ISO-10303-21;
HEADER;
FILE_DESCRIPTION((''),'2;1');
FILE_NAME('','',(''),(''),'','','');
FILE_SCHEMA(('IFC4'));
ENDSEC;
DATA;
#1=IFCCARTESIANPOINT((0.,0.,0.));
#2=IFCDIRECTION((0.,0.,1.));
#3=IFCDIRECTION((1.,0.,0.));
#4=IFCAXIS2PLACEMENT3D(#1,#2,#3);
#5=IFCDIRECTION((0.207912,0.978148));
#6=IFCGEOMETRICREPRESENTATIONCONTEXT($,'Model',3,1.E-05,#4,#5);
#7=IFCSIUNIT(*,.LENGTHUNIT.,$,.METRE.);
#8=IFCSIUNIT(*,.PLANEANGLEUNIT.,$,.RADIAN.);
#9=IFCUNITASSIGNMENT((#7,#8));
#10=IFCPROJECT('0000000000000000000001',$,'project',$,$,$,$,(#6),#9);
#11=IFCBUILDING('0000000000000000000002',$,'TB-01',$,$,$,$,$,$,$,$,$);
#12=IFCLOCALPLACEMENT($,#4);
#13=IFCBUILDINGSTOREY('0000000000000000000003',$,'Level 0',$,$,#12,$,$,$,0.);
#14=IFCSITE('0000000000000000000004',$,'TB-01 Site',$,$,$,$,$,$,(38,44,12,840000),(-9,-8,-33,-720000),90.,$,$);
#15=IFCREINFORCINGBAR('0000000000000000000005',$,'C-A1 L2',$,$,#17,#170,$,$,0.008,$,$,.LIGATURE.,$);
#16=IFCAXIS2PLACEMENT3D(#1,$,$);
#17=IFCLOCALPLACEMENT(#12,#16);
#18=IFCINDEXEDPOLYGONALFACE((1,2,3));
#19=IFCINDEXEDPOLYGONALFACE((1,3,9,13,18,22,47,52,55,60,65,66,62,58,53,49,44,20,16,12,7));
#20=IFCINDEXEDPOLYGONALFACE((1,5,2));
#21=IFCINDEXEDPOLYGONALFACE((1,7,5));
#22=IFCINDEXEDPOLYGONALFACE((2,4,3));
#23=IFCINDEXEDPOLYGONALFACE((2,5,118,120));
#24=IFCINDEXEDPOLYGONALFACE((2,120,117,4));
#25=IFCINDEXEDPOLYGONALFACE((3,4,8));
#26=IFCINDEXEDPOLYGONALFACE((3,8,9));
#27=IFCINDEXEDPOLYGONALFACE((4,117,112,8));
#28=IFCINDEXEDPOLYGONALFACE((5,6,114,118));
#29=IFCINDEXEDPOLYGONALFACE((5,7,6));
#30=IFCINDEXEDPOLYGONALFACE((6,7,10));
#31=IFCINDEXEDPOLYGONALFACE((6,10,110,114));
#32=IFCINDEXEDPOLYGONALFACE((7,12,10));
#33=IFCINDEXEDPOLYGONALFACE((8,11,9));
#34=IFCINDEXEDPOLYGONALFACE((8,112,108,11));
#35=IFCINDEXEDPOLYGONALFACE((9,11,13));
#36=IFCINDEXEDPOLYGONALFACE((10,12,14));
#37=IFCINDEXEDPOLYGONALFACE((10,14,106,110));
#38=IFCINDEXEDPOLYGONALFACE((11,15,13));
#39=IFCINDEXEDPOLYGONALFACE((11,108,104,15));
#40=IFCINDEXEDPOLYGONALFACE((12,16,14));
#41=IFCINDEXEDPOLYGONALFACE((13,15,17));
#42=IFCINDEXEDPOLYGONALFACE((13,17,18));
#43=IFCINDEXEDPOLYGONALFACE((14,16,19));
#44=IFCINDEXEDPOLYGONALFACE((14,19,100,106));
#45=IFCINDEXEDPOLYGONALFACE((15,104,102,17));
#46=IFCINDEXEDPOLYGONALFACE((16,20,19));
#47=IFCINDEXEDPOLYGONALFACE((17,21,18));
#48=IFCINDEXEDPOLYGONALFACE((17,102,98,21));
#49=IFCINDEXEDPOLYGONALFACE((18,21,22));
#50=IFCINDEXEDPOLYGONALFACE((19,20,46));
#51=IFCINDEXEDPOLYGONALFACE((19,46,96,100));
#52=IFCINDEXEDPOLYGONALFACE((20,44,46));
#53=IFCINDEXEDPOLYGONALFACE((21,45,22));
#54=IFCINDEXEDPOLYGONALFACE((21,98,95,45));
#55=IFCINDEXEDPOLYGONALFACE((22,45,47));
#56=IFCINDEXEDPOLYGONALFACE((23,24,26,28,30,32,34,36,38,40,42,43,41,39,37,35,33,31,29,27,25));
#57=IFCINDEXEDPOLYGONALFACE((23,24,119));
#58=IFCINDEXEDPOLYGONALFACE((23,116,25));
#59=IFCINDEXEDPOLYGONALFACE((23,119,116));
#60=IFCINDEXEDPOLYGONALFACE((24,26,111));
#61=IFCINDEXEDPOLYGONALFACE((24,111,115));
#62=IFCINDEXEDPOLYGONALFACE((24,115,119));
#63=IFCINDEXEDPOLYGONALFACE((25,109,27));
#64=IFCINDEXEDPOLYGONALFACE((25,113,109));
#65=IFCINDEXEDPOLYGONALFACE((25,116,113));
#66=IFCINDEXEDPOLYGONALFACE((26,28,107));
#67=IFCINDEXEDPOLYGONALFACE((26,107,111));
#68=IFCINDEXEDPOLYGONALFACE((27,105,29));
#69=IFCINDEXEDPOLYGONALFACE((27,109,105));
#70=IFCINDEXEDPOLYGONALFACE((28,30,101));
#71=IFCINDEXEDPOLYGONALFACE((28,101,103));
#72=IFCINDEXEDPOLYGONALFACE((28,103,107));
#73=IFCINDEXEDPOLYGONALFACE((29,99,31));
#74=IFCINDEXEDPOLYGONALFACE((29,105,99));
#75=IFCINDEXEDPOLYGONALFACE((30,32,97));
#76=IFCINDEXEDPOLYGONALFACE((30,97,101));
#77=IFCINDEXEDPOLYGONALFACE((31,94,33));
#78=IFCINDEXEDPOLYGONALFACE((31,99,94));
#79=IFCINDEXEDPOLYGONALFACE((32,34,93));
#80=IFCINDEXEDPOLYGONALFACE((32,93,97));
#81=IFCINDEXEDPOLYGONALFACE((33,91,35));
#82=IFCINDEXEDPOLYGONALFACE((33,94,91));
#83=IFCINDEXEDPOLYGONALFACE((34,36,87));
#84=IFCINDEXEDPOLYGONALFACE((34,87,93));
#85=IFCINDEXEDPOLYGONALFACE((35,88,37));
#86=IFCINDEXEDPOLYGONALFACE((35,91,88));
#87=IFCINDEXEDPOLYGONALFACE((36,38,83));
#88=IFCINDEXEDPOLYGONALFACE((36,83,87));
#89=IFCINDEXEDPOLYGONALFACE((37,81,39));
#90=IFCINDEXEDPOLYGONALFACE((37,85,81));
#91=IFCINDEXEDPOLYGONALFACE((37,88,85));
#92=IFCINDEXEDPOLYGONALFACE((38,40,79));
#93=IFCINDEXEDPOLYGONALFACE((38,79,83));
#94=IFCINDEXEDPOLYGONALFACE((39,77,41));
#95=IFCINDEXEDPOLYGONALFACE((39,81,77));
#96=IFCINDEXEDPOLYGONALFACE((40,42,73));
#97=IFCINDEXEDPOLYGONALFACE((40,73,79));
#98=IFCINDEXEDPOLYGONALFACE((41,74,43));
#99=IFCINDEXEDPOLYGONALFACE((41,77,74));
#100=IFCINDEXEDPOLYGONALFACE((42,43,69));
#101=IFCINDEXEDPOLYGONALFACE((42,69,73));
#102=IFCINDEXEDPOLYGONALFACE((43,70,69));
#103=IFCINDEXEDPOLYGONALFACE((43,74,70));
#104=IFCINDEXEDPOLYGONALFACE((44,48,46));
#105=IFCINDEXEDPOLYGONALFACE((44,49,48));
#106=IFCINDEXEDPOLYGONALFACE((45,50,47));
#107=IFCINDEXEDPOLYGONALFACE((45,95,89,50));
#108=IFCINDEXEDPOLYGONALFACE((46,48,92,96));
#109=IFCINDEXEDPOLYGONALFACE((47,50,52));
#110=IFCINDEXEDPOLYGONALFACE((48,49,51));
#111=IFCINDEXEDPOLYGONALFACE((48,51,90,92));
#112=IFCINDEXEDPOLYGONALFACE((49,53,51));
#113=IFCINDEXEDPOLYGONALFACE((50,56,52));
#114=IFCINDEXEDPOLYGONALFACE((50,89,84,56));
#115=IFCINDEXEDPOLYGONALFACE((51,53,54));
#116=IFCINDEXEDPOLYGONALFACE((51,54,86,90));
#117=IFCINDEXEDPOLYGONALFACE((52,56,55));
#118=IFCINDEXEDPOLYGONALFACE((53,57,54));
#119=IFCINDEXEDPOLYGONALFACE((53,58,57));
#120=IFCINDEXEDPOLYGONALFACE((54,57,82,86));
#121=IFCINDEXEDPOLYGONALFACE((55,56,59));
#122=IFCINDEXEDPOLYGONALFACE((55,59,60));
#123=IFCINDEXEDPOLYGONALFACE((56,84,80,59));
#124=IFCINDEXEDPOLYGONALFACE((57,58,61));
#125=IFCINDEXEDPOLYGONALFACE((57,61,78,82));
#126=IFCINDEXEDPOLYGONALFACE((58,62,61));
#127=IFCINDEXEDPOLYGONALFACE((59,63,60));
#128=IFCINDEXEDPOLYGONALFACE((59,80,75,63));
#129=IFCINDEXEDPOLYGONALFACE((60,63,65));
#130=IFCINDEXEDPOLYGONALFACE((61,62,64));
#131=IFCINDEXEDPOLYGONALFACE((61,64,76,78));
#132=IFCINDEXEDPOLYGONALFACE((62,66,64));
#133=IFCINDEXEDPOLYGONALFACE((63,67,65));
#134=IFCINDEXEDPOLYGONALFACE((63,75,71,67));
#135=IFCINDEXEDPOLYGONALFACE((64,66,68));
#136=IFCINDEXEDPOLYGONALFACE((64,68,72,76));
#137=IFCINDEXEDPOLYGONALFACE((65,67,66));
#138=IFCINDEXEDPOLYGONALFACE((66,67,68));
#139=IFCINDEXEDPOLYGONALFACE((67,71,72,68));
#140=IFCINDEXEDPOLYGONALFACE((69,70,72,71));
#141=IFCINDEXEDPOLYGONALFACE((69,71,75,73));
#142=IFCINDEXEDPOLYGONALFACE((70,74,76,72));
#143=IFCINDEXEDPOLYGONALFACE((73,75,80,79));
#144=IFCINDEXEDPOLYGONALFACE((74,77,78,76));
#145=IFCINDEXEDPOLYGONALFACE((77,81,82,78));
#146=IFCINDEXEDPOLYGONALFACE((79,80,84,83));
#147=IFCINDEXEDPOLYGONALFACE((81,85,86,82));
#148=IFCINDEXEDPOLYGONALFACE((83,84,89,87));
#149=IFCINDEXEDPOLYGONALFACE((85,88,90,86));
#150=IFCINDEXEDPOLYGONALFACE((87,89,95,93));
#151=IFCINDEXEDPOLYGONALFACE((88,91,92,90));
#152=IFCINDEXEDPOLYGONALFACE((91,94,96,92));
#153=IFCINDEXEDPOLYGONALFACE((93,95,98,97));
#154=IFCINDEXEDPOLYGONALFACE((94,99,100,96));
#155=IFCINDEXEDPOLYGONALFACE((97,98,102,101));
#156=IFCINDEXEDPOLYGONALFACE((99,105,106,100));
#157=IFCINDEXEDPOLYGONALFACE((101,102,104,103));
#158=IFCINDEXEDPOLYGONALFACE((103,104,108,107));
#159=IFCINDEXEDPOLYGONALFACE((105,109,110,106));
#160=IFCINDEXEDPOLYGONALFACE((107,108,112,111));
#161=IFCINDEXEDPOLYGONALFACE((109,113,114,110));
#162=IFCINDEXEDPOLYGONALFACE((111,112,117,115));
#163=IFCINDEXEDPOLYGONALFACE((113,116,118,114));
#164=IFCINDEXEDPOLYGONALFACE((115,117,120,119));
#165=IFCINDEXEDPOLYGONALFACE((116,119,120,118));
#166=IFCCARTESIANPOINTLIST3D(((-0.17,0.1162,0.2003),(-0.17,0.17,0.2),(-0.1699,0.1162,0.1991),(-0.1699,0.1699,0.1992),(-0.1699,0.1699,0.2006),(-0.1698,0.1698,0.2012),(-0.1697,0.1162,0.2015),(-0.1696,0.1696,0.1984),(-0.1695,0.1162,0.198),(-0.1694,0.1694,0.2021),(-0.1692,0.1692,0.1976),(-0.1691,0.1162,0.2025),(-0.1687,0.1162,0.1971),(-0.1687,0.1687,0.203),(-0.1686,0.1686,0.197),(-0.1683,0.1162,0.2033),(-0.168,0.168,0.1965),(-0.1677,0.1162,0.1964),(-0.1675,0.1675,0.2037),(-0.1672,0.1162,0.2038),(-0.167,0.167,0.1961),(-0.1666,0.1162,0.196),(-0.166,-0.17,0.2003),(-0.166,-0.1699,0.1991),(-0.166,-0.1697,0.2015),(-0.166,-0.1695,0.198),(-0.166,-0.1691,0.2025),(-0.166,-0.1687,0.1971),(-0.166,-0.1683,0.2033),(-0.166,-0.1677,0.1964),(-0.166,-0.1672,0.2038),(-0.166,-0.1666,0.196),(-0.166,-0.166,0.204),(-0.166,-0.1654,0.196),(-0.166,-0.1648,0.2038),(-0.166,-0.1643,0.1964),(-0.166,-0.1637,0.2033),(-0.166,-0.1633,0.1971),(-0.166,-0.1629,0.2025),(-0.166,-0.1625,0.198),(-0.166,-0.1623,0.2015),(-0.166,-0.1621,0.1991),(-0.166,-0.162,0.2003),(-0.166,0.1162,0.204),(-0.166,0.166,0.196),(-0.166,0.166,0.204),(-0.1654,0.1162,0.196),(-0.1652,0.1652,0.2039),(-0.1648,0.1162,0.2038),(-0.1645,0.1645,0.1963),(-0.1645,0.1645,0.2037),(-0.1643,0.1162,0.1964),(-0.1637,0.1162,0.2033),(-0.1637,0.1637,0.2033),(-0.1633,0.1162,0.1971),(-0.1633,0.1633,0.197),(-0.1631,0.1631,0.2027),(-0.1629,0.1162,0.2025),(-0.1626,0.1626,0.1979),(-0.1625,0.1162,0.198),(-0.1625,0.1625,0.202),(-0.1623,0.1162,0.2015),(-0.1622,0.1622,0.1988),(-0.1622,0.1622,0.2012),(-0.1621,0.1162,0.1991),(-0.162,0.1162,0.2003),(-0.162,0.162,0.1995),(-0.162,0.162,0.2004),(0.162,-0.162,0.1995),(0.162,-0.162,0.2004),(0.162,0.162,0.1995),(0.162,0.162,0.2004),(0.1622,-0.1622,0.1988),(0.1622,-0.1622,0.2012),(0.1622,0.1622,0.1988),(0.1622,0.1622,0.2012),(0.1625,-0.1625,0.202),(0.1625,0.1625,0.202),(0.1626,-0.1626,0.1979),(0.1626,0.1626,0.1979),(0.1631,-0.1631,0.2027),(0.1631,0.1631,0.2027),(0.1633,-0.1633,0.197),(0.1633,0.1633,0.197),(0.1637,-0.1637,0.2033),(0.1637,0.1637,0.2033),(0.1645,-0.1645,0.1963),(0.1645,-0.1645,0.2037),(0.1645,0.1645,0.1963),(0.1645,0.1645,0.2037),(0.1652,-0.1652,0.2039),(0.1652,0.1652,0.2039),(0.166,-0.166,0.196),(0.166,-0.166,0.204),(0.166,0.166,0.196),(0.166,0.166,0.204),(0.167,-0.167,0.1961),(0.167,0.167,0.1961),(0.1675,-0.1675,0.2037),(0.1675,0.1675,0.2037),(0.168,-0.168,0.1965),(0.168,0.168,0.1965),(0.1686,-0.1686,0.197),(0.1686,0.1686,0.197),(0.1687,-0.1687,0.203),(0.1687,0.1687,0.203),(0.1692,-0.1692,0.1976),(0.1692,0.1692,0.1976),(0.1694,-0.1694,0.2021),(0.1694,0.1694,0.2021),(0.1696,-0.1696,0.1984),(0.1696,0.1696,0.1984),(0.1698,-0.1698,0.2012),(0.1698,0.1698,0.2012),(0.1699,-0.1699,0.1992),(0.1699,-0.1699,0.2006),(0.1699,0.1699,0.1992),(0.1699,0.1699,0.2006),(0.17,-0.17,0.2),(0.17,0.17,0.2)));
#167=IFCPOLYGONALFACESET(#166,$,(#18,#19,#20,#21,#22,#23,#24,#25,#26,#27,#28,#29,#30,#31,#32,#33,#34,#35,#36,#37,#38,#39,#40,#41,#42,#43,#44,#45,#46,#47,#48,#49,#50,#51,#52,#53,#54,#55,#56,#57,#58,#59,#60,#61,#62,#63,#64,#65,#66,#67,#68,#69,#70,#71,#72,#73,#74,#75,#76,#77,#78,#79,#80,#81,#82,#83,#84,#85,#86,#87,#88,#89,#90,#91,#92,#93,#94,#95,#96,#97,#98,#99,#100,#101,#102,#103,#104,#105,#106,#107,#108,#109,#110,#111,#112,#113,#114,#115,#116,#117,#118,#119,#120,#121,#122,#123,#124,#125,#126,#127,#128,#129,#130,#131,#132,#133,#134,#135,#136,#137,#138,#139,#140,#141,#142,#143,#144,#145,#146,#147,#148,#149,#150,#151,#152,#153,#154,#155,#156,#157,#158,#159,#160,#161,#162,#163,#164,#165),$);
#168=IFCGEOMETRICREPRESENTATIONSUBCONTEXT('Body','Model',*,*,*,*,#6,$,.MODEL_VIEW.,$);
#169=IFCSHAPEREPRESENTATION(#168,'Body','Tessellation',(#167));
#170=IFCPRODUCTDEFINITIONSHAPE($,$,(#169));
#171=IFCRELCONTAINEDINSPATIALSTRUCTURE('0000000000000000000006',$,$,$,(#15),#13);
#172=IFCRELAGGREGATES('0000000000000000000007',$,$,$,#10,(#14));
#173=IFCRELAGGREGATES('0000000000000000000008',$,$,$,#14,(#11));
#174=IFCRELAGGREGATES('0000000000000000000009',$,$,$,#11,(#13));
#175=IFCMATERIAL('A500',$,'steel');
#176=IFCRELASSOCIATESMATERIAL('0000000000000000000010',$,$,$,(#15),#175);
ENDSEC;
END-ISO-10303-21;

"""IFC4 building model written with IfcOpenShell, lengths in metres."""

from ifc_helpers import new_model, entity, si_unit, direction, origin_with_axes, place, context, subcontext, project, spatial, material, element, save


model = new_model("IFC4")

# Units and contexts
model_context = context("Model", 3, precision=1e-05, world=origin_with_axes(), true_north=direction((0.207912, 0.978148)))
body_context = subcontext(model_context, "Body", "Model", "MODEL_VIEW")
ifc_project = project(units=[si_unit("LENGTHUNIT", "METRE"), si_unit("PLANEANGLEUNIT", "RADIAN")], contexts=[model_context])

# Site, building, storey
site = spatial("IfcSite", under=ifc_project, Name="TB-01 Site", RefLatitude=(38, 44, 12, 840000), RefLongitude=(-9, -8, -33, -720000), RefElevation=90.0)
building = spatial("IfcBuilding", under=site, Name="TB-01")
storey_placement = place(None, origin_with_axes())
storey = spatial("IfcBuildingStorey", under=building, at=storey_placement, Name="Level 0", Elevation=0.0)

# Reinforcing bar
ifc_material_1 = material(Name="A500", Category="steel")
reinforcing_bar_1_placement = place(storey_placement, origin_with_axes())
element("IfcReinforcingBar", 1, at=reinforcing_bar_1_placement, inside=storey, material=ifc_material_1, Name="C-A1 L2", NominalDiameter=0.008, PredefinedType="LIGATURE", context=body_context, shape_type="AdvancedSweptSolid", body=[
    entity("IfcSweptDiskSolid", entity("IfcPolyline", [entity("IfcCartesianPoint", [-0.166, -0.166, 0.2]), entity("IfcCartesianPoint", [0.166, -0.166, 0.2]), entity("IfcCartesianPoint", [0.166, 0.166, 0.2]), entity("IfcCartesianPoint", [-0.166, 0.166, 0.2]), entity("IfcCartesianPoint", [-0.166, 0.1162, 0.2])]), 0.004),
])

save(model, "model.ifc")
